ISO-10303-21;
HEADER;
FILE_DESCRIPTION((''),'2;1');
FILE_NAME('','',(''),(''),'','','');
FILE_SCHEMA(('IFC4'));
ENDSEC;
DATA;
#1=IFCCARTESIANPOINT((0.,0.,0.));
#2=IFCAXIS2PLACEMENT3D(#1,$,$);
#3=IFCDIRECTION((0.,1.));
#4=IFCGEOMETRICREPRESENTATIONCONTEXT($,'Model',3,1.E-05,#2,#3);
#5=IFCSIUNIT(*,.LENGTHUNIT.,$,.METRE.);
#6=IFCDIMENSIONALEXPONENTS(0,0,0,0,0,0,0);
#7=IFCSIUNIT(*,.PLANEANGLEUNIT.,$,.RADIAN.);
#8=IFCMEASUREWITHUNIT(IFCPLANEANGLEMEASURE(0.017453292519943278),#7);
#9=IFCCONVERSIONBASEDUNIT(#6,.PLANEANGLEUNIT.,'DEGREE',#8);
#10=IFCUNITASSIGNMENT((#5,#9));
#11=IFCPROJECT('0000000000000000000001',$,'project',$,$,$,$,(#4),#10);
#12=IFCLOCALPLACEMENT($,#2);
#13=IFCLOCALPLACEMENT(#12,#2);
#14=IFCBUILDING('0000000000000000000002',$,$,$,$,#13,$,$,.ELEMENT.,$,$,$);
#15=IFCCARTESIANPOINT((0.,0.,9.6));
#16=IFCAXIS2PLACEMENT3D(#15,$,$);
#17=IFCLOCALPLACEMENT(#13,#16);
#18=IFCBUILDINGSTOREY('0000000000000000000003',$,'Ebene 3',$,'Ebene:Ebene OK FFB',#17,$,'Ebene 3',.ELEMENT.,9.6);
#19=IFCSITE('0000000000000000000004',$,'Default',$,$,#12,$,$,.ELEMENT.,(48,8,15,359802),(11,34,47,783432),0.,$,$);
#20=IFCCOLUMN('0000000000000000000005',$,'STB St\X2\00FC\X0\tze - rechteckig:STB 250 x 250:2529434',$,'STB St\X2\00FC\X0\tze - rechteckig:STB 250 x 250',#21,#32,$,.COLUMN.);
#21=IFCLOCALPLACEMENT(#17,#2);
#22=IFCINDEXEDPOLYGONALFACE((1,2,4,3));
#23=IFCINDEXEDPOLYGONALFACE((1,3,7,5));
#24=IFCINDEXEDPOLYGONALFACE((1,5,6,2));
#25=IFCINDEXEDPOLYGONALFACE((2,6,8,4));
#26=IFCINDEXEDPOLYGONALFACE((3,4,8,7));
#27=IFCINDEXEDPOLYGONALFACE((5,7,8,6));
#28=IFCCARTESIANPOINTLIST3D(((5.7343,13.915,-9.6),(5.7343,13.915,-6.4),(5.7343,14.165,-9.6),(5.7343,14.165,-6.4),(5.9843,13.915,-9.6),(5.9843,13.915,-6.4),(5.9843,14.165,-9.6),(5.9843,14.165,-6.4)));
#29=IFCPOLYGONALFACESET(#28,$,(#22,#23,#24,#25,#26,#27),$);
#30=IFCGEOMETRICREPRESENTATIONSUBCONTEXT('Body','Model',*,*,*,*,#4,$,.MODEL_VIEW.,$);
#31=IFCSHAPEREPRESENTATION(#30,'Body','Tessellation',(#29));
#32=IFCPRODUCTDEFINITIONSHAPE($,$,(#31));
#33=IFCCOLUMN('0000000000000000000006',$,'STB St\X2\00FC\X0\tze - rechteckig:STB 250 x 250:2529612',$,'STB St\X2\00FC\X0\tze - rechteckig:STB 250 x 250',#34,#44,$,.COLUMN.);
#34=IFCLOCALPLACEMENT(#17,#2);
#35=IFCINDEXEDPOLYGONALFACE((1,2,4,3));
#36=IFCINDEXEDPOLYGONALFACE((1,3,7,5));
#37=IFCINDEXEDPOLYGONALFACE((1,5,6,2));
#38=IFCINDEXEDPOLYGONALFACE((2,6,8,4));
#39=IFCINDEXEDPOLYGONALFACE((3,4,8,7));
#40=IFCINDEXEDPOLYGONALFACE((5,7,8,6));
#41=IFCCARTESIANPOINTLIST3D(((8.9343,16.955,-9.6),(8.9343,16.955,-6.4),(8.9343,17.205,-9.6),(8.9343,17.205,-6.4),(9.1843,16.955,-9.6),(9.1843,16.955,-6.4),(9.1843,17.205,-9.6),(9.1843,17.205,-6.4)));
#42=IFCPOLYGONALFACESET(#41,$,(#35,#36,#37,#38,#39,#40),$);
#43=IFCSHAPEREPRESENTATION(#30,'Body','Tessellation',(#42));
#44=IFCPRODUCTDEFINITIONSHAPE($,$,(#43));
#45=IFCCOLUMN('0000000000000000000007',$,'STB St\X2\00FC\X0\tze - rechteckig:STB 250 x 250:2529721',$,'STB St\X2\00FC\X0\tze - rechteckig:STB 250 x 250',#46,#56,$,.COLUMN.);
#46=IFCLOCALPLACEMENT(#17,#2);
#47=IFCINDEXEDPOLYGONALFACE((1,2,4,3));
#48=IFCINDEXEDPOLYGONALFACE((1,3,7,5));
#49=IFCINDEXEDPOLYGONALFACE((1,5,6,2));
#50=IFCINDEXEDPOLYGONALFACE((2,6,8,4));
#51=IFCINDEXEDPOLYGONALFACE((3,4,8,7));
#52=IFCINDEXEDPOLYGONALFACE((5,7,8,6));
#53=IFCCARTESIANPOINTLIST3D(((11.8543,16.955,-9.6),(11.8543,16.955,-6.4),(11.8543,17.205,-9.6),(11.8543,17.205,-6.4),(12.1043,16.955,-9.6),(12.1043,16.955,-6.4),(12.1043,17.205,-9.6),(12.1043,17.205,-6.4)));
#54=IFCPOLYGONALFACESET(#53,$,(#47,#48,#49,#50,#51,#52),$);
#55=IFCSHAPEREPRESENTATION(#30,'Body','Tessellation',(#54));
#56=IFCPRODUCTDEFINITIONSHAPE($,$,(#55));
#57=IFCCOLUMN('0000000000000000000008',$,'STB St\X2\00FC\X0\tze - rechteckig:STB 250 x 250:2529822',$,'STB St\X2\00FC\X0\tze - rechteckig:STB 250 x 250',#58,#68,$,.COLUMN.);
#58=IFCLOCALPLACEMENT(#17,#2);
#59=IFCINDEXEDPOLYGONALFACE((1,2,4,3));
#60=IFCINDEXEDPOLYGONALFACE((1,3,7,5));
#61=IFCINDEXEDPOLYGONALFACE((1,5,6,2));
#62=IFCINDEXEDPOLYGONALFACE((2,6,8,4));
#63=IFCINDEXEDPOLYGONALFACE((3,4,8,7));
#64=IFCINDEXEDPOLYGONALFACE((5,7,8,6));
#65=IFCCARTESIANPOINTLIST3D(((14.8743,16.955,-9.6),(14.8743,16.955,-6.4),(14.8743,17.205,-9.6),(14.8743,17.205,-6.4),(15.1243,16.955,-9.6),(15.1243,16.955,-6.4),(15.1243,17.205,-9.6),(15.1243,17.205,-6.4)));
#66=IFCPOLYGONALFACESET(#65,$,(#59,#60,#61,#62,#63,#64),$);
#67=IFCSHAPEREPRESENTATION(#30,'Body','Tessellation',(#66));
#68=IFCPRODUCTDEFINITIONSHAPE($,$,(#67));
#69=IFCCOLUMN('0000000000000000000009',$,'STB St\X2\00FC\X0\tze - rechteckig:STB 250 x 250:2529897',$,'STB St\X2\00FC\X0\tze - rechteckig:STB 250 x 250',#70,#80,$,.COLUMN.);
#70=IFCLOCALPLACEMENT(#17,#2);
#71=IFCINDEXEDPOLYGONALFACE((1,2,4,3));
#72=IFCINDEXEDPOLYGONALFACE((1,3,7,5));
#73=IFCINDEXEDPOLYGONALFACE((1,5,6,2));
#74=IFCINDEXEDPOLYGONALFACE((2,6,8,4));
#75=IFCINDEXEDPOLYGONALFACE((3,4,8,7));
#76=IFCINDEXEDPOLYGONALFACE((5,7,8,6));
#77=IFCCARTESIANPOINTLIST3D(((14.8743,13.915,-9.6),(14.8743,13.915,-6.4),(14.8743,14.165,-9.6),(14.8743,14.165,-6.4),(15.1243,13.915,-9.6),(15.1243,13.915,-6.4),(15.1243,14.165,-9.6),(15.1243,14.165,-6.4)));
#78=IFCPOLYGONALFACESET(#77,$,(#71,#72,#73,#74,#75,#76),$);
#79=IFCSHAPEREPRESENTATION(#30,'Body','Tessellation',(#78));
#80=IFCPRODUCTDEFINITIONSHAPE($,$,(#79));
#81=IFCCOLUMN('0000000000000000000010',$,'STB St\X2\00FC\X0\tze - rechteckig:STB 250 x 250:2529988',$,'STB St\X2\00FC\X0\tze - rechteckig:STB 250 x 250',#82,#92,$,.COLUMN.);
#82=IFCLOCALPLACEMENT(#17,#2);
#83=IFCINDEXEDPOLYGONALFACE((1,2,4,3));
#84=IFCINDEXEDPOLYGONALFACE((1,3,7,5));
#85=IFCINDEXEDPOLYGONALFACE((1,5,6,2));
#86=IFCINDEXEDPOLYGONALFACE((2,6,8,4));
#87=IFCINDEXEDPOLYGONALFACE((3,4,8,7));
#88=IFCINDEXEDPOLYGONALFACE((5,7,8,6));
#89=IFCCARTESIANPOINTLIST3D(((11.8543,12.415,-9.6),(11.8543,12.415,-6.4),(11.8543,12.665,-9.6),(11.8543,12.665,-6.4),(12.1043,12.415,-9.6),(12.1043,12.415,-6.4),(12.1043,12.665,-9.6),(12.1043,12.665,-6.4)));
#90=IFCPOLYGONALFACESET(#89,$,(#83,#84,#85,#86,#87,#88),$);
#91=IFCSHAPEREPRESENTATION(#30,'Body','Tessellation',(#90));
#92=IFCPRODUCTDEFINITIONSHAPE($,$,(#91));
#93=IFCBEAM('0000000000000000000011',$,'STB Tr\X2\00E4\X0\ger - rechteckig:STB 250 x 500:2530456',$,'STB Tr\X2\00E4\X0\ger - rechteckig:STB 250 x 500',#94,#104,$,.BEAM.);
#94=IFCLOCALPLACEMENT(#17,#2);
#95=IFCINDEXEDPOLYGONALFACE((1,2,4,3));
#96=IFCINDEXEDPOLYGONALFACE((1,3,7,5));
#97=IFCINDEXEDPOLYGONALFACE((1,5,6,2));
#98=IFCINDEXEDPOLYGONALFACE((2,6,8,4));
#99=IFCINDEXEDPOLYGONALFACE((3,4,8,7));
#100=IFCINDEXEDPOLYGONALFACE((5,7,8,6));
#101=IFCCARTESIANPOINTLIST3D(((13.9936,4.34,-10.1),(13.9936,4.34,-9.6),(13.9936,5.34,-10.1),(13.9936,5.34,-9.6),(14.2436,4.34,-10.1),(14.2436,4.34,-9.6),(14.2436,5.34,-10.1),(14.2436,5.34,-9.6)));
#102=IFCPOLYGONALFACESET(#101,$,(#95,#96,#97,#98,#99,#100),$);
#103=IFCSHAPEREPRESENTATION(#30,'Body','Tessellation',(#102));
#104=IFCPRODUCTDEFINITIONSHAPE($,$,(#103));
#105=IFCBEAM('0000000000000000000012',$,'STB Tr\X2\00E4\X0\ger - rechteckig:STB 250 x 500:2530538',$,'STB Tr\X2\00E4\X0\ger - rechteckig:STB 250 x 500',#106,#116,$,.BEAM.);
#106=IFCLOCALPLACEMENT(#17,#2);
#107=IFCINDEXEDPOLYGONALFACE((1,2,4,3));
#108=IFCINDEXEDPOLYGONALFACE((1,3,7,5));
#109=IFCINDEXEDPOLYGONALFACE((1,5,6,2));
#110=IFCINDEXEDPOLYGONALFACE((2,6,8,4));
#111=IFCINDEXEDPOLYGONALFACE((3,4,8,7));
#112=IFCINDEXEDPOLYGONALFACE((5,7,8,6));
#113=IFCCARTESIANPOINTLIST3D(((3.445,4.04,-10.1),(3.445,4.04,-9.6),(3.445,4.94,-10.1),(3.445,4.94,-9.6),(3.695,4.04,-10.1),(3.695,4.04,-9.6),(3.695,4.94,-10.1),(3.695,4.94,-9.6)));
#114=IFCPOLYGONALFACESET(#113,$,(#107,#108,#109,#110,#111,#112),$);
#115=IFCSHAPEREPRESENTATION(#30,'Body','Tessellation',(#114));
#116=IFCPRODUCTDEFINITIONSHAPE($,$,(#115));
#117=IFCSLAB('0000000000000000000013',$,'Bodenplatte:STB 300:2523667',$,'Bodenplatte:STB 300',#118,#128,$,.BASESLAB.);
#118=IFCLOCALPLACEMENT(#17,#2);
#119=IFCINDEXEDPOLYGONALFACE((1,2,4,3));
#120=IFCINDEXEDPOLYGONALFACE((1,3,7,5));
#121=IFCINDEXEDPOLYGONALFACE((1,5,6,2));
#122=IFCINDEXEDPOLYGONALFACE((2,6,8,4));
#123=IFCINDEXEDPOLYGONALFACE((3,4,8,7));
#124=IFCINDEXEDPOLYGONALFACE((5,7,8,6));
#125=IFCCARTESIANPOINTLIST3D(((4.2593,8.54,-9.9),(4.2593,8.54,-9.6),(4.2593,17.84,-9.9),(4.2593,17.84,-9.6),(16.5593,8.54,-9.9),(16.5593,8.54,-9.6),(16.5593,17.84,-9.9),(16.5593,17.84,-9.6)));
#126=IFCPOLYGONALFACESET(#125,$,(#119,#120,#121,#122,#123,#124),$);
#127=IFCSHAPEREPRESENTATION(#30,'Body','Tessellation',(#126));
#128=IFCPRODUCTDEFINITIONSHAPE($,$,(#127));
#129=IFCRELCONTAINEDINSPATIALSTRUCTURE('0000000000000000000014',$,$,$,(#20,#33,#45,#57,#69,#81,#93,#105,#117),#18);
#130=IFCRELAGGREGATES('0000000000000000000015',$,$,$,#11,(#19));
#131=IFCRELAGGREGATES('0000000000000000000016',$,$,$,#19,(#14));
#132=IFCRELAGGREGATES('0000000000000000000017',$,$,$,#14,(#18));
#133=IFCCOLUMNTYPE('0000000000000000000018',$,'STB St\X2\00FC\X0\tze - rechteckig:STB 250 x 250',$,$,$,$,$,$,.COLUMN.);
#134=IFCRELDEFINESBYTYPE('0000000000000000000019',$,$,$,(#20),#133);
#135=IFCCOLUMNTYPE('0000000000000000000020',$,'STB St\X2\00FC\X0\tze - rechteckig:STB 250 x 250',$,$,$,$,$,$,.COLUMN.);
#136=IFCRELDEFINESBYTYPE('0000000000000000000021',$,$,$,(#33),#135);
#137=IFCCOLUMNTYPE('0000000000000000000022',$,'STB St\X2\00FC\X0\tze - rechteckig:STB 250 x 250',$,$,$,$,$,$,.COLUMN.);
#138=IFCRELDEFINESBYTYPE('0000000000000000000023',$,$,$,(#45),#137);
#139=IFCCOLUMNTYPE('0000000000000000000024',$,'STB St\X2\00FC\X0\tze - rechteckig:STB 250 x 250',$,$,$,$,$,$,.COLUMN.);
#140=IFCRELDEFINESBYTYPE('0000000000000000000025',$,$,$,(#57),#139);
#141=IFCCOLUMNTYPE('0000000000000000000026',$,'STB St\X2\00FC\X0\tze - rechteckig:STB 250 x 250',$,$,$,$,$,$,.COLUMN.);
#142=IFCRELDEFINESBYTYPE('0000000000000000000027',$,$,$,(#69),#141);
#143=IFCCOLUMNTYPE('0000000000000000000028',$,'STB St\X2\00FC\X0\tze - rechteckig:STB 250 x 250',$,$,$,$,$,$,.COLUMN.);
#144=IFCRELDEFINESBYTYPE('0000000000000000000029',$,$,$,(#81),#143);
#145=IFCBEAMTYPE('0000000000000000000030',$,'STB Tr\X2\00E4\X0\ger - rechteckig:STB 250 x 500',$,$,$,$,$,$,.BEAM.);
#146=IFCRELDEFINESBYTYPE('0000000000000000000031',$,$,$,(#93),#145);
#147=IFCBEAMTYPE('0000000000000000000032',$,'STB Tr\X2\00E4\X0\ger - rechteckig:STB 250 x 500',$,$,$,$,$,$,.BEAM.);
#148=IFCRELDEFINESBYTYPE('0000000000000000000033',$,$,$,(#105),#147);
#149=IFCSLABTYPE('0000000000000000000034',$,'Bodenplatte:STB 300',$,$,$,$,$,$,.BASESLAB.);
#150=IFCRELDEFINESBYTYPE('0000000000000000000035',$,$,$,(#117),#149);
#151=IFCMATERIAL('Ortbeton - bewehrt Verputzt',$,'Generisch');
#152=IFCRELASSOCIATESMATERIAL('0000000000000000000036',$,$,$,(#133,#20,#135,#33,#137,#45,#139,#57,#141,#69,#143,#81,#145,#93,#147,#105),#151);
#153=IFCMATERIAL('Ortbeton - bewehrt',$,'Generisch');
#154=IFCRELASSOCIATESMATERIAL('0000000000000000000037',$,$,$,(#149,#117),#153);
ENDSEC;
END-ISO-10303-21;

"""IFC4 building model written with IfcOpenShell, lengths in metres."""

from ifc_helpers import new_model, entity, si_unit, converted_unit, direction, frame, origin, place, context, subcontext, project, spatial, indexed_curve, outline, extrude, source, transform, mapped, material, type_object, type_shapes, element, save


model = new_model("IFC4")

# Units and contexts
model_context = context("Model", 3, precision=1e-05, world=origin(), true_north=direction((0.0, 1.0)))
body_context = subcontext(model_context, "Body", "Model", "MODEL_VIEW")
ifc_project = project(units=[si_unit("LENGTHUNIT", "METRE"), converted_unit("PLANEANGLEUNIT", "DEGREE", entity("IfcPlaneAngleMeasure", 0.017453292519943278), si_unit("PLANEANGLEUNIT", "RADIAN"), dimensions=[0, 0, 0, 0, 0, 0, 0])], contexts=[model_context])

# Site, building, storey
site_placement = place(None, origin())
site = spatial("IfcSite", under=ifc_project, at=site_placement, Name="Default", CompositionType="ELEMENT", RefLatitude=(48, 8, 15, 359802), RefLongitude=(11, 34, 47, 783432), RefElevation=0.0)
building_placement = place(site_placement, origin())
building = spatial("IfcBuilding", under=site, at=building_placement, CompositionType="ELEMENT")
storey_placement = place(building_placement, frame((0.0, 0.0, 9.6)))
storey = spatial("IfcBuildingStorey", under=building, at=storey_placement, Name="Ebene 3", ObjectType="Ebene:Ebene OK FFB", LongName="Ebene 3", CompositionType="ELEMENT", Elevation=9.6)

# Columns
ifc_material_1 = material(Name="Ortbeton - bewehrt Verputzt", Category="Generisch")
column_type_1 = type_object("IfcColumnType", Name="STB Stütze - rechteckig:STB 250 x 250", PredefinedType="COLUMN", material=ifc_material_1)
shared_shape_1 = source(origin(), body_context, "Body", "SweptSolid", [
    extrude(outline(indexed_curve([(-0.125, -0.125), (0.125, -0.125), (0.125, 0.125), (-0.125, 0.125), (-0.125, -0.125)], self_intersect=False)), frame((5.8593, 14.04, 0.0), z_axis=(0.0, 0.0, 1.0), x_axis=(-1.0, 0.0, 0.0)), (0.0, 0.0, 1.0), 3.2),
])
type_shapes(column_type_1, [shared_shape_1])
column_1_placement = place(storey_placement, frame((0.0, 0.0, -9.6)))
element("IfcColumn", 1, at=column_1_placement, inside=storey, type_object=column_type_1, material=ifc_material_1, Name="STB Stütze - rechteckig:STB 250 x 250:2529434", ObjectType="STB Stütze - rechteckig:STB 250 x 250", PredefinedType="COLUMN", context=body_context, shape_type="MappedRepresentation", body=[
    mapped(shared_shape_1, transform((0.0, 0.0, 0.0), scale=1.0)),
])
column_type_2 = type_object("IfcColumnType", Name="STB Stütze - rechteckig:STB 250 x 250", PredefinedType="COLUMN", material=ifc_material_1)
shared_shape_2 = source(origin(), body_context, "Body", "SweptSolid", [
    extrude(outline(indexed_curve([(-0.125, -0.125), (0.125, -0.125), (0.125, 0.125), (-0.125, 0.125), (-0.125, -0.125)], self_intersect=False)), frame((9.0593, 17.08, 0.0), z_axis=(0.0, 0.0, 1.0), x_axis=(-1.0, 0.0, 0.0)), (0.0, 0.0, 1.0), 3.2),
])
type_shapes(column_type_2, [shared_shape_2])
column_2_placement = place(storey_placement, frame((0.0, 0.0, -9.6)))
element("IfcColumn", 2, at=column_2_placement, inside=storey, type_object=column_type_2, material=ifc_material_1, Name="STB Stütze - rechteckig:STB 250 x 250:2529612", ObjectType="STB Stütze - rechteckig:STB 250 x 250", PredefinedType="COLUMN", context=body_context, shape_type="MappedRepresentation", body=[
    mapped(shared_shape_2, transform((0.0, 0.0, 0.0), scale=1.0)),
])
column_type_3 = type_object("IfcColumnType", Name="STB Stütze - rechteckig:STB 250 x 250", PredefinedType="COLUMN", material=ifc_material_1)
shared_shape_3 = source(origin(), body_context, "Body", "SweptSolid", [
    extrude(outline(indexed_curve([(-0.125, -0.125), (0.125, -0.125), (0.125, 0.125), (-0.125, 0.125), (-0.125, -0.125)], self_intersect=False)), frame((11.9793, 17.08, 0.0), z_axis=(0.0, 0.0, 1.0), x_axis=(-1.0, 0.0, 0.0)), (0.0, 0.0, 1.0), 3.2),
])
type_shapes(column_type_3, [shared_shape_3])
column_3_placement = place(storey_placement, frame((0.0, 0.0, -9.6)))
element("IfcColumn", 3, at=column_3_placement, inside=storey, type_object=column_type_3, material=ifc_material_1, Name="STB Stütze - rechteckig:STB 250 x 250:2529721", ObjectType="STB Stütze - rechteckig:STB 250 x 250", PredefinedType="COLUMN", context=body_context, shape_type="MappedRepresentation", body=[
    mapped(shared_shape_3, transform((0.0, 0.0, 0.0), scale=1.0)),
])
column_type_4 = type_object("IfcColumnType", Name="STB Stütze - rechteckig:STB 250 x 250", PredefinedType="COLUMN", material=ifc_material_1)
shared_shape_4 = source(origin(), body_context, "Body", "SweptSolid", [
    extrude(outline(indexed_curve([(-0.125, -0.125), (0.125, -0.125), (0.125, 0.125), (-0.125, 0.125), (-0.125, -0.125)], self_intersect=False)), frame((14.9993, 17.08, 0.0), z_axis=(0.0, 0.0, 1.0), x_axis=(-1.0, 0.0, 0.0)), (0.0, 0.0, 1.0), 3.2),
])
type_shapes(column_type_4, [shared_shape_4])
column_4_placement = place(storey_placement, frame((0.0, 0.0, -9.6)))
element("IfcColumn", 4, at=column_4_placement, inside=storey, type_object=column_type_4, material=ifc_material_1, Name="STB Stütze - rechteckig:STB 250 x 250:2529822", ObjectType="STB Stütze - rechteckig:STB 250 x 250", PredefinedType="COLUMN", context=body_context, shape_type="MappedRepresentation", body=[
    mapped(shared_shape_4, transform((0.0, 0.0, 0.0), scale=1.0)),
])
column_type_5 = type_object("IfcColumnType", Name="STB Stütze - rechteckig:STB 250 x 250", PredefinedType="COLUMN", material=ifc_material_1)
shared_shape_5 = source(origin(), body_context, "Body", "SweptSolid", [
    extrude(outline(indexed_curve([(-0.125, -0.125), (0.125, -0.125), (0.125, 0.125), (-0.125, 0.125), (-0.125, -0.125)], self_intersect=False)), frame((14.9993, 14.04, 0.0), z_axis=(0.0, 0.0, 1.0), x_axis=(-1.0, 0.0, 0.0)), (0.0, 0.0, 1.0), 3.2),
])
type_shapes(column_type_5, [shared_shape_5])
column_5_placement = place(storey_placement, frame((0.0, 0.0, -9.6)))
element("IfcColumn", 5, at=column_5_placement, inside=storey, type_object=column_type_5, material=ifc_material_1, Name="STB Stütze - rechteckig:STB 250 x 250:2529897", ObjectType="STB Stütze - rechteckig:STB 250 x 250", PredefinedType="COLUMN", context=body_context, shape_type="MappedRepresentation", body=[
    mapped(shared_shape_5, transform((0.0, 0.0, 0.0), scale=1.0)),
])
column_type_6 = type_object("IfcColumnType", Name="STB Stütze - rechteckig:STB 250 x 250", PredefinedType="COLUMN", material=ifc_material_1)
shared_shape_6 = source(origin(), body_context, "Body", "SweptSolid", [
    extrude(outline(indexed_curve([(-0.125, -0.125), (0.125, -0.125), (0.125, 0.125), (-0.125, 0.125), (-0.125, -0.125)], self_intersect=False)), frame((11.9793, 12.54, 0.0), z_axis=(0.0, 0.0, 1.0), x_axis=(-1.0, 0.0, 0.0)), (0.0, 0.0, 1.0), 3.2),
])
type_shapes(column_type_6, [shared_shape_6])
column_6_placement = place(storey_placement, frame((0.0, 0.0, -9.6)))
element("IfcColumn", 6, at=column_6_placement, inside=storey, type_object=column_type_6, material=ifc_material_1, Name="STB Stütze - rechteckig:STB 250 x 250:2529988", ObjectType="STB Stütze - rechteckig:STB 250 x 250", PredefinedType="COLUMN", context=body_context, shape_type="MappedRepresentation", body=[
    mapped(shared_shape_6, transform((0.0, 0.0, 0.0), scale=1.0)),
])

# Beams
beam_type_1 = type_object("IfcBeamType", Name="STB Träger - rechteckig:STB 250 x 500", PredefinedType="BEAM", material=ifc_material_1)
shared_shape_7 = source(origin(), body_context, "Body", "SweptSolid", [
    extrude(outline(indexed_curve([(-0.125, -0.25), (0.125, -0.25), (0.125, 0.25), (-0.125, 0.25), (-0.125, -0.25)], self_intersect=False)), frame((14.1186, 5.34, -0.25), z_axis=(0.0, -1.0, 0.0), x_axis=(-1.0, 0.0, 0.0)), (0.0, 0.0, 1.0), 1.0),
])
type_shapes(beam_type_1, [shared_shape_7])
beam_1_placement = place(storey_placement, frame((0.0, 0.0, -9.6)))
element("IfcBeam", 7, at=beam_1_placement, inside=storey, type_object=beam_type_1, material=ifc_material_1, Name="STB Träger - rechteckig:STB 250 x 500:2530456", ObjectType="STB Träger - rechteckig:STB 250 x 500", PredefinedType="BEAM", context=body_context, shape_type="MappedRepresentation", body=[
    mapped(shared_shape_7, transform((0.0, 0.0, 0.0), scale=1.0)),
])
beam_type_2 = type_object("IfcBeamType", Name="STB Träger - rechteckig:STB 250 x 500", PredefinedType="BEAM", material=ifc_material_1)
shared_shape_8 = source(origin(), body_context, "Body", "SweptSolid", [
    extrude(outline(indexed_curve([(-0.125, -0.25), (0.125, -0.25), (0.125, 0.25), (-0.125, 0.25), (-0.125, -0.25)], self_intersect=False)), frame((3.57, 4.94, -0.25), z_axis=(0.0, -1.0, 0.0), x_axis=(-1.0, 0.0, 0.0)), (0.0, 0.0, 1.0), 0.9),
])
type_shapes(beam_type_2, [shared_shape_8])
beam_2_placement = place(storey_placement, frame((0.0, 0.0, -9.6)))
element("IfcBeam", 8, at=beam_2_placement, inside=storey, type_object=beam_type_2, material=ifc_material_1, Name="STB Träger - rechteckig:STB 250 x 500:2530538", ObjectType="STB Träger - rechteckig:STB 250 x 500", PredefinedType="BEAM", context=body_context, shape_type="MappedRepresentation", body=[
    mapped(shared_shape_8, transform((0.0, 0.0, 0.0), scale=1.0)),
])

# Slab
ifc_material_2 = material(Name="Ortbeton - bewehrt", Category="Generisch")
slab_type = type_object("IfcSlabType", Name="Bodenplatte:STB 300", PredefinedType="BASESLAB", material=ifc_material_2)
slab_placement = place(storey_placement, origin())
element("IfcSlab", 9, at=slab_placement, inside=storey, type_object=slab_type, material=ifc_material_2, Name="Bodenplatte:STB 300:2523667", ObjectType="Bodenplatte:STB 300", PredefinedType="BASESLAB", context=body_context, shape_type="SweptSolid", body=[
    extrude(outline(indexed_curve([(-4.65, -6.15), (4.65, -6.15), (4.65, 6.15), (-4.65, 6.15), (-4.65, -6.15)], self_intersect=False)), frame((10.4093, 13.19, -9.6), z_axis=(0.0, 0.0, -1.0), x_axis=(0.0, 1.0, 0.0)), (0.0, 0.0, 1.0), 0.3),
])

save(model, "model.ifc")
